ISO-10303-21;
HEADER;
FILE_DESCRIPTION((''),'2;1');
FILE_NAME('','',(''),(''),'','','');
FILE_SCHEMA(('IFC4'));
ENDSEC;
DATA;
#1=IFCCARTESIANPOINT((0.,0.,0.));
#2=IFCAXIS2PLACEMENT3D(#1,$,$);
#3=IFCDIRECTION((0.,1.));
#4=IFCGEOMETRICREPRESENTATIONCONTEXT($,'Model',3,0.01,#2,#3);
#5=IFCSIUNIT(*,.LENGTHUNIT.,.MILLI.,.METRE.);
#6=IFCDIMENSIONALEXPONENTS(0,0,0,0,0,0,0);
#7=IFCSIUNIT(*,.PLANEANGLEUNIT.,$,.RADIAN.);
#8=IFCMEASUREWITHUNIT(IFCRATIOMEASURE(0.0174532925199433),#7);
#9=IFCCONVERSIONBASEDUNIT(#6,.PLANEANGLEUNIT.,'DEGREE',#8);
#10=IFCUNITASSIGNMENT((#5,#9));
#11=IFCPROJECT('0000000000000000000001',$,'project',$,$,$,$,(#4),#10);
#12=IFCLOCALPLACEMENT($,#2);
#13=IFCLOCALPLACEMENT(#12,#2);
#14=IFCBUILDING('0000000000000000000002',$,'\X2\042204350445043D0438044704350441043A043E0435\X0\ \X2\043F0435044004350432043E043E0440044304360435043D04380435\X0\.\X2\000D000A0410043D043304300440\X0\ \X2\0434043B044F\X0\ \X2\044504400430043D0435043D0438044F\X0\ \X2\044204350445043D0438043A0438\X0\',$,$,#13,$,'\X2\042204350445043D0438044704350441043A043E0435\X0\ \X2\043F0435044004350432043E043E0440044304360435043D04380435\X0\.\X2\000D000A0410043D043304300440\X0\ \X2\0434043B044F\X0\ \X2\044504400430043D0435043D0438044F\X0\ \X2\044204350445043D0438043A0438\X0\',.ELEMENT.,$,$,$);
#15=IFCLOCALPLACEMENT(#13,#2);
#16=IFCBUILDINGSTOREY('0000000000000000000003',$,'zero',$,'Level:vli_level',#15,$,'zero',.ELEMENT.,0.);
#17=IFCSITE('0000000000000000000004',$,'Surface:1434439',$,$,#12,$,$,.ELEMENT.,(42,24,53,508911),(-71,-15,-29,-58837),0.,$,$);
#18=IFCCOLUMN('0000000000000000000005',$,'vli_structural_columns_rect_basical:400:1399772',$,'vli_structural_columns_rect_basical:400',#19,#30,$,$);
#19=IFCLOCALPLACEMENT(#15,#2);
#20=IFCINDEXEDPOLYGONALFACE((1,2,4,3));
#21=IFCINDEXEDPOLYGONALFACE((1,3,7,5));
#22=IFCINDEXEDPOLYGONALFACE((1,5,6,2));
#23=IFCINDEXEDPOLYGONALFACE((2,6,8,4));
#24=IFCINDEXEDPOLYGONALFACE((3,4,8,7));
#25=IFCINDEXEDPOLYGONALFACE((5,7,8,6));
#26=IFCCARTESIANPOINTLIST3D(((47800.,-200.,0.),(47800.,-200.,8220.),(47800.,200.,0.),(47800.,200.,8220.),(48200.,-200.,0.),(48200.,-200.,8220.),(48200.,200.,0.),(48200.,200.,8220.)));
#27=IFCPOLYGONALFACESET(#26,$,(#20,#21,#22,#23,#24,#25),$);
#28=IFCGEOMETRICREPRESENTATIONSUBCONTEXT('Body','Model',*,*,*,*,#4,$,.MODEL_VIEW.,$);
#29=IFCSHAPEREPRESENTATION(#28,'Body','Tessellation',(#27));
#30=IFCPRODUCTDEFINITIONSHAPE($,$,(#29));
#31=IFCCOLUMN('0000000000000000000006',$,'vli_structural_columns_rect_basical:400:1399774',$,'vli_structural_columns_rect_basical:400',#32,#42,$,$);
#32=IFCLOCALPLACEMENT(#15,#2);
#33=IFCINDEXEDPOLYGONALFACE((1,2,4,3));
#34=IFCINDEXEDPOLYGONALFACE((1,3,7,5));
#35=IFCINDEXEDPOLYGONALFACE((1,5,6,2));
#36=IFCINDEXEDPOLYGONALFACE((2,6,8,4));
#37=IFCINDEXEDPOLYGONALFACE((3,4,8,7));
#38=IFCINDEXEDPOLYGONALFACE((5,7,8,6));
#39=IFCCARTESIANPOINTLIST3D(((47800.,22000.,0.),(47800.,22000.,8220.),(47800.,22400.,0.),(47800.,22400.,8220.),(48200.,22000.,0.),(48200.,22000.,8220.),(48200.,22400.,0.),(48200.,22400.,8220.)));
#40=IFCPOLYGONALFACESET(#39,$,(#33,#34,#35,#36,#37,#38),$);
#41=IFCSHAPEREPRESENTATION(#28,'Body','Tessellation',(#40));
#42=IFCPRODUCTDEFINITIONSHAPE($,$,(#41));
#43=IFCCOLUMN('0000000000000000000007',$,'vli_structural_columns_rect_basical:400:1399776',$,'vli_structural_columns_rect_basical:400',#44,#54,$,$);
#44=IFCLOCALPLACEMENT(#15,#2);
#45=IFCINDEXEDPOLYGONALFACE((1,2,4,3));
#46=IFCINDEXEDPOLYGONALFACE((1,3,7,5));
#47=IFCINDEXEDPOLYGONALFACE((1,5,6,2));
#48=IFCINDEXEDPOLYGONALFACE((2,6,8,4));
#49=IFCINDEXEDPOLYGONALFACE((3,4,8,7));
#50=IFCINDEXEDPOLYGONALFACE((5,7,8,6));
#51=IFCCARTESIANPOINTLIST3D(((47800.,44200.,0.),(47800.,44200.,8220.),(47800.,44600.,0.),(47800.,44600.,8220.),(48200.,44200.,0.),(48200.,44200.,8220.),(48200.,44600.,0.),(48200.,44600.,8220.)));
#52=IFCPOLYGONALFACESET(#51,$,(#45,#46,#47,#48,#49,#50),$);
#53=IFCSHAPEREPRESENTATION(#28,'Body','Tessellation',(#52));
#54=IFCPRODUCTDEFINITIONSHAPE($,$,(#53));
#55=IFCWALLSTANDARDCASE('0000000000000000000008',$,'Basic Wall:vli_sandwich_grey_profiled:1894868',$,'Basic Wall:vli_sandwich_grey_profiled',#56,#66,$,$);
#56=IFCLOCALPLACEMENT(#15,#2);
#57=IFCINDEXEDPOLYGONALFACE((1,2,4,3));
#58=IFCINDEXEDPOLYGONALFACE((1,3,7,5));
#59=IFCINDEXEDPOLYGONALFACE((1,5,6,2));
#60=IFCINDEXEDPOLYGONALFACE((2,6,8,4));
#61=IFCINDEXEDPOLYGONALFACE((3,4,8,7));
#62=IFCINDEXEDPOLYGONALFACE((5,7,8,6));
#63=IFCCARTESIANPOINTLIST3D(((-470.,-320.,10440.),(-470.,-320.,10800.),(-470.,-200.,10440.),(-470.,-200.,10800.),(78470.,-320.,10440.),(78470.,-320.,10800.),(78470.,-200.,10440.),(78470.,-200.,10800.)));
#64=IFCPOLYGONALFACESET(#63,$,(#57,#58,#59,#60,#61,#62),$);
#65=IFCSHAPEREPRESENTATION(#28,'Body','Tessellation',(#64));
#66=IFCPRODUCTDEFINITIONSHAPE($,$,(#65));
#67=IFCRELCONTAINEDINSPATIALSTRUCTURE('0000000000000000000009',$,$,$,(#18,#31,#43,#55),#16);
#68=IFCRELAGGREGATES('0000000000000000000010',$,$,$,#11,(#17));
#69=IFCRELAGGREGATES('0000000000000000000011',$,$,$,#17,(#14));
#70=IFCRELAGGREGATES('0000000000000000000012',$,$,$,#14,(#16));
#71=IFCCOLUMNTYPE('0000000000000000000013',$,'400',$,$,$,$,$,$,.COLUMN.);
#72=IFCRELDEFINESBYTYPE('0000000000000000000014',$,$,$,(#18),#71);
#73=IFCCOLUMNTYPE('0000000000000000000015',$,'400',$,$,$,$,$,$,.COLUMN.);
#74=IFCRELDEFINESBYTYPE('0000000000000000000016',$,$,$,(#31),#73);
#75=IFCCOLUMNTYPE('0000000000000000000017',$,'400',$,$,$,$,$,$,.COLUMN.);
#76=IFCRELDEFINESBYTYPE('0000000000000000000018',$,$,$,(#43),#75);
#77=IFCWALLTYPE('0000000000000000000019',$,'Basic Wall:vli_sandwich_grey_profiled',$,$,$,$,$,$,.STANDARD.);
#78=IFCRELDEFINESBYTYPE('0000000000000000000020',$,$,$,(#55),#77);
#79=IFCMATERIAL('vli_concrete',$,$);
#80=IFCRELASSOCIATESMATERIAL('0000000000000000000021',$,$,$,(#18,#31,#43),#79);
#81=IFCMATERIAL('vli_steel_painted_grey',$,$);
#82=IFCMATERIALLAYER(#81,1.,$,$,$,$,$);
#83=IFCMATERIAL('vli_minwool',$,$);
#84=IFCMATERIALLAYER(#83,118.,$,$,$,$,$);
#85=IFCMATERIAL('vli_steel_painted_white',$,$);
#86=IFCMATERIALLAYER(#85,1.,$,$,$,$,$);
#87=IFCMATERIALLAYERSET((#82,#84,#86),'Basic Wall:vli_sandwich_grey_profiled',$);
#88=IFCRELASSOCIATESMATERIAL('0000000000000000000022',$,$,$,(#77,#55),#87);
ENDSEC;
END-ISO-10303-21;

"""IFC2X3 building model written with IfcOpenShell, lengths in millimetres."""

from ifc_helpers import new_model, entity, si_unit, converted_unit, direction, frame, frame_2d, origin, origin_2d_with_axis, place, context, subcontext, project, spatial, rectangle, extrude, source, transform, mapped, material, layer, layer_set, layer_usage, type_object, type_shapes, element, save


model = new_model("IFC2X3")

# Units and contexts
model_context = context("Model", 3, precision=0.01, world=origin(), true_north=direction((0.0, 1.0)))
body_context = subcontext(model_context, "Body", "Model", "MODEL_VIEW")
ifc_project = project(units=[si_unit("LENGTHUNIT", "METRE", prefix="MILLI"), converted_unit("PLANEANGLEUNIT", "DEGREE", entity("IfcRatioMeasure", 0.0174532925199433), si_unit("PLANEANGLEUNIT", "RADIAN"), dimensions=[0, 0, 0, 0, 0, 0, 0])], contexts=[model_context])

# Site, building, storey
site_placement = place(None, origin())
site = spatial("IfcSite", under=ifc_project, at=site_placement, Name="Surface:1434439", CompositionType="ELEMENT", RefLatitude=(42, 24, 53, 508911), RefLongitude=(-71, -15, -29, -58837), RefElevation=0.0)
building_placement = place(site_placement, origin())
building = spatial("IfcBuilding", under=site, at=building_placement, Name="Техническое перевооружение.\r\nАнгар для хранения техники", LongName="Техническое перевооружение.\r\nАнгар для хранения техники", CompositionType="ELEMENT")
storey_placement = place(building_placement, origin())
storey = spatial("IfcBuildingStorey", under=building, at=storey_placement, Name="zero", ObjectType="Level:vli_level", LongName="zero", CompositionType="ELEMENT", Elevation=0.0)

# Columns
ifc_material_1 = material(Name="vli_concrete")
column_type_1 = type_object("IfcColumnType", Name="400", PredefinedType="COLUMN")
shared_shape_1 = source(origin(), body_context, "Body", "SweptSolid", [
    extrude(rectangle(XDim=400.0, YDim=400.0, at=origin_2d_with_axis()), frame((48000.0, 0.0, 0.0), z_axis=(0.0, 0.0, 1.0), x_axis=(0.0, -1.0, 0.0)), (0.0, 0.0, 1.0), 8220.0),
])
type_shapes(column_type_1, [shared_shape_1])
column_1_placement = place(storey_placement, origin())
element("IfcColumn", 1, at=column_1_placement, inside=storey, type_object=column_type_1, material=ifc_material_1, Name="vli_structural_columns_rect_basical:400:1399772", ObjectType="vli_structural_columns_rect_basical:400", context=body_context, shape_type="MappedRepresentation", body=[
    mapped(shared_shape_1, transform((0.0, 0.0, 0.0), scale=1.0)),
])
column_type_2 = type_object("IfcColumnType", Name="400", PredefinedType="COLUMN")
shared_shape_2 = source(origin(), body_context, "Body", "SweptSolid", [
    extrude(rectangle(XDim=400.0, YDim=400.0, at=frame_2d((0.0, 0.0), x_axis=(1.0, 0.0))), frame((48000.0, 22200.0, 0.0), z_axis=(0.0, 0.0, 1.0), x_axis=(0.0, -1.0, 0.0)), (0.0, 0.0, 1.0), 8220.0),
])
type_shapes(column_type_2, [shared_shape_2])
column_2_placement = place(storey_placement, origin())
element("IfcColumn", 2, at=column_2_placement, inside=storey, type_object=column_type_2, material=ifc_material_1, Name="vli_structural_columns_rect_basical:400:1399774", ObjectType="vli_structural_columns_rect_basical:400", context=body_context, shape_type="MappedRepresentation", body=[
    mapped(shared_shape_2, transform((0.0, 0.0, 0.0), scale=1.0)),
])
column_type_3 = type_object("IfcColumnType", Name="400", PredefinedType="COLUMN")
shared_shape_3 = source(origin(), body_context, "Body", "SweptSolid", [
    extrude(rectangle(XDim=400.0, YDim=400.0, at=origin_2d_with_axis()), frame((48000.0, 44400.0, 0.0), z_axis=(0.0, 0.0, 1.0), x_axis=(0.0, -1.0, 0.0)), (0.0, 0.0, 1.0), 8220.0),
])
type_shapes(column_type_3, [shared_shape_3])
column_3_placement = place(storey_placement, origin())
element("IfcColumn", 3, at=column_3_placement, inside=storey, type_object=column_type_3, material=ifc_material_1, Name="vli_structural_columns_rect_basical:400:1399776", ObjectType="vli_structural_columns_rect_basical:400", context=body_context, shape_type="MappedRepresentation", body=[
    mapped(shared_shape_3, transform((0.0, 0.0, 0.0), scale=1.0)),
])

# Wall
ifc_material_2 = material(Name="vli_steel_painted_grey")
ifc_layer_1 = layer(ifc_material_2, 1.0)
ifc_material_3 = material(Name="vli_minwool")
ifc_layer_2 = layer(ifc_material_3, 118.0)
ifc_material_4 = material(Name="vli_steel_painted_white")
ifc_layer_3 = layer(ifc_material_4, 1.0)
ifc_layer_set = layer_set([ifc_layer_1, ifc_layer_2, ifc_layer_3], Name="Basic Wall:vli_sandwich_grey_profiled")
ifc_layer_usage = layer_usage(ifc_layer_set, "AXIS2", "POSITIVE", -60.0)
wall_type = type_object("IfcWallType", Name="Basic Wall:vli_sandwich_grey_profiled", PredefinedType="STANDARD", material=ifc_layer_set)
wall_placement = place(storey_placement, frame((-470.0, -260.0, 10440.0)))
element("IfcWallStandardCase", 4, at=wall_placement, inside=storey, type_object=wall_type, material=ifc_layer_usage, Name="Basic Wall:vli_sandwich_grey_profiled:1894868", ObjectType="Basic Wall:vli_sandwich_grey_profiled", context=body_context, shape_type="SweptSolid", body=[
    extrude(rectangle(XDim=78940.0, YDim=120.0, at=frame_2d((39470.0, 0.0), x_axis=(-1.0, 0.0))), origin(), (0.0, 0.0, 1.0), 360.0),
])

save(model, "model.ifc")
